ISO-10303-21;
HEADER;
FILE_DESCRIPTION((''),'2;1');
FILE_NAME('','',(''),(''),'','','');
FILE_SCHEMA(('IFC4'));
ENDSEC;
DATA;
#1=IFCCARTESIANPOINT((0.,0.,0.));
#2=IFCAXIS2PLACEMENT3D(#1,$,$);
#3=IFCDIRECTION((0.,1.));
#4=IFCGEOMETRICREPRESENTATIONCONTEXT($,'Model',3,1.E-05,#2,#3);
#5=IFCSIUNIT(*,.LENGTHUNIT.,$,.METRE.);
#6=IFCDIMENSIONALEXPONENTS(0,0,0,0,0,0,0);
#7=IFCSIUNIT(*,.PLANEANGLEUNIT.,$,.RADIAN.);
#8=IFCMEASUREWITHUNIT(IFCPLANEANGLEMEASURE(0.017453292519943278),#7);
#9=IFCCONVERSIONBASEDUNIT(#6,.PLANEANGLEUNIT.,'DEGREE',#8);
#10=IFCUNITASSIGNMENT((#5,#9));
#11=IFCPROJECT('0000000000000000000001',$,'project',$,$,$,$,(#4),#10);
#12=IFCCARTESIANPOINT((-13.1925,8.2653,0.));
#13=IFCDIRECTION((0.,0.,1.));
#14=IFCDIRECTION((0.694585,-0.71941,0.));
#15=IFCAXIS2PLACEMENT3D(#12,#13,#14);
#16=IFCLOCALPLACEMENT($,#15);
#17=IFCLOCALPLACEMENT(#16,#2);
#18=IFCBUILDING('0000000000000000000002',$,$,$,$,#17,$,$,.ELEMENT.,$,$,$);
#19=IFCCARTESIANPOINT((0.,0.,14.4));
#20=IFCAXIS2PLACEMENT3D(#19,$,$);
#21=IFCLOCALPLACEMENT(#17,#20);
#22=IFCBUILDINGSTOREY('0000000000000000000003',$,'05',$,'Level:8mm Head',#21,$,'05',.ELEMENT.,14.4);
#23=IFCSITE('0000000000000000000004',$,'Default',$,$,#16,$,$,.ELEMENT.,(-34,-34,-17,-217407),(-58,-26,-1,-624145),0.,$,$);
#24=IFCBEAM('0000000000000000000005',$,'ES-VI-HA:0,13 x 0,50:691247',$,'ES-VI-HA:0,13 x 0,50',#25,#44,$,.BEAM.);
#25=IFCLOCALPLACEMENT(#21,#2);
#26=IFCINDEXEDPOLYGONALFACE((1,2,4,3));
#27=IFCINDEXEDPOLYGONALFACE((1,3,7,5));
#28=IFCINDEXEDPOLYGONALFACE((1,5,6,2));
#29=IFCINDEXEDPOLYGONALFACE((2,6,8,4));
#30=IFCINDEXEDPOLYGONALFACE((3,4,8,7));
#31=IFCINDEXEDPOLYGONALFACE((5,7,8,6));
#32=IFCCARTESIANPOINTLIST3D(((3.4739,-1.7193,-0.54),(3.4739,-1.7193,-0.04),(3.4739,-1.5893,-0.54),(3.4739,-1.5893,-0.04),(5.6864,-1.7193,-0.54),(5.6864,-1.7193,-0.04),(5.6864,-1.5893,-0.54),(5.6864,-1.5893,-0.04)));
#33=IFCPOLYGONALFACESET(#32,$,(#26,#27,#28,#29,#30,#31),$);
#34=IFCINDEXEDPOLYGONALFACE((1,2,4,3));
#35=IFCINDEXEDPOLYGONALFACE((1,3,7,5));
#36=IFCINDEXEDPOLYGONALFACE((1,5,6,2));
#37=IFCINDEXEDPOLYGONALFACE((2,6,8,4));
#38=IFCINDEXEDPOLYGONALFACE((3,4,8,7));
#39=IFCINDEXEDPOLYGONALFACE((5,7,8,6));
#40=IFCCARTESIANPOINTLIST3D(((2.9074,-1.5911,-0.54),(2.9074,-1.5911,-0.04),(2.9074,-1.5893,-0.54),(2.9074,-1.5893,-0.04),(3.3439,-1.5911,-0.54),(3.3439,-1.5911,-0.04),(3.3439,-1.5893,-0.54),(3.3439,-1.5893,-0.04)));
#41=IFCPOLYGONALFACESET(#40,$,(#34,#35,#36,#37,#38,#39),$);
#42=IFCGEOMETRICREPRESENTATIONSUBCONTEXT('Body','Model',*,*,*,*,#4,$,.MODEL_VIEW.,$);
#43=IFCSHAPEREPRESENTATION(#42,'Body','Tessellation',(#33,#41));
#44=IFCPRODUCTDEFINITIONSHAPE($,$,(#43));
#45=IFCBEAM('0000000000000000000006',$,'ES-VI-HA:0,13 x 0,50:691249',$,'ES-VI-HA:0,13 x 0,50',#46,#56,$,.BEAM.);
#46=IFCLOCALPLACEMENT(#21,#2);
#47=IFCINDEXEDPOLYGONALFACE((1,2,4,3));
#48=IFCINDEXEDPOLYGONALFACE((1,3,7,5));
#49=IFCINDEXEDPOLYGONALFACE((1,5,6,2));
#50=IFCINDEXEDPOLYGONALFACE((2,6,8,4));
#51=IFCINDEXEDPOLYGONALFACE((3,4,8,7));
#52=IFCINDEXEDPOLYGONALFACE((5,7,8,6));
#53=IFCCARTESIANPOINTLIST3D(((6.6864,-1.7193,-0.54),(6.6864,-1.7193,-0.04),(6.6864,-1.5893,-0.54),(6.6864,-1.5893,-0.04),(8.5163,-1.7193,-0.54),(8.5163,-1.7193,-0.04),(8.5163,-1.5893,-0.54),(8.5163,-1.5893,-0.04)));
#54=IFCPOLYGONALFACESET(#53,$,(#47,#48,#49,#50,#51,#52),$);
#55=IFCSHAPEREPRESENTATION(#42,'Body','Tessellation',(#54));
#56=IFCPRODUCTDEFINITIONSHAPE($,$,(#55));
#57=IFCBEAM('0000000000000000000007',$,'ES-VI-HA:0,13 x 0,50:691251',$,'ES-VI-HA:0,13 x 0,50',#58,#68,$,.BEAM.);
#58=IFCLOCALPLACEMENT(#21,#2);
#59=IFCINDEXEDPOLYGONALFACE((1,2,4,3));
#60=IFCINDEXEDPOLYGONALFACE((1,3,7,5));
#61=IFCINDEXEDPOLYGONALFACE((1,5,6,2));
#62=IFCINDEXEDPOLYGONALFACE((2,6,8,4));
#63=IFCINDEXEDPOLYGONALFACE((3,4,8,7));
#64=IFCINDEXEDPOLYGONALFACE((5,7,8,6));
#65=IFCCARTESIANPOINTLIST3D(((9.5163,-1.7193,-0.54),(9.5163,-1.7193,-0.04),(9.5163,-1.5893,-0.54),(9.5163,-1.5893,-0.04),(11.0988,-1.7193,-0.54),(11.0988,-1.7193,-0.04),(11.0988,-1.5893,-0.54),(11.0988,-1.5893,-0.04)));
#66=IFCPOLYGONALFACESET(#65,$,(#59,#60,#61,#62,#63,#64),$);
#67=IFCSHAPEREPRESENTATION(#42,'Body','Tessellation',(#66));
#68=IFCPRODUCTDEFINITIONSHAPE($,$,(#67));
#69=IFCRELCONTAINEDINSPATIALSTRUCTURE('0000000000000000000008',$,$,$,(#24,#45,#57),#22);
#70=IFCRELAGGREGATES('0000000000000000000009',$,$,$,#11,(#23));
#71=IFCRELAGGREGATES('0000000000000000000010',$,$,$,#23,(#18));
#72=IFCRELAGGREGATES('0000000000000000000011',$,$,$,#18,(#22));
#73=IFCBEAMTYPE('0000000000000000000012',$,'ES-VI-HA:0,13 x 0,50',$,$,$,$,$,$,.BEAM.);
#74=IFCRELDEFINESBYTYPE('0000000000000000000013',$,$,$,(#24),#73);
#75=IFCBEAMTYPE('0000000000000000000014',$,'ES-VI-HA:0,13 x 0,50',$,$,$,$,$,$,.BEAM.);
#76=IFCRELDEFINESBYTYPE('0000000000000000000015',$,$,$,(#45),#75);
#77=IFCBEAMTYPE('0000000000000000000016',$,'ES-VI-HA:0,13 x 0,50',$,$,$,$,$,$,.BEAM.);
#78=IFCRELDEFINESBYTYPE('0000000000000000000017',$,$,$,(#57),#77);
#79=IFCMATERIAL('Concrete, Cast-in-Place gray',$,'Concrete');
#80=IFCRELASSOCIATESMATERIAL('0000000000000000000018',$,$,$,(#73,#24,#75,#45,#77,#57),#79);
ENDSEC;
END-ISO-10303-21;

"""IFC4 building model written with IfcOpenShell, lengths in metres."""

from ifc_helpers import new_model, entity, si_unit, converted_unit, direction, frame, origin, place, context, subcontext, project, spatial, indexed_curve, outline, extrude, source, transform, mapped, material, type_object, type_shapes, element, save


model = new_model("IFC4")

# Units and contexts
model_context = context("Model", 3, precision=1e-05, world=origin(), true_north=direction((0.0, 1.0)))
body_context = subcontext(model_context, "Body", "Model", "MODEL_VIEW")
ifc_project = project(units=[si_unit("LENGTHUNIT", "METRE"), converted_unit("PLANEANGLEUNIT", "DEGREE", entity("IfcPlaneAngleMeasure", 0.017453292519943278), si_unit("PLANEANGLEUNIT", "RADIAN"), dimensions=[0, 0, 0, 0, 0, 0, 0])], contexts=[model_context])

# Site, building, storey
site_placement = place(None, frame((-13.1925, 8.2653, 0.0), z_axis=(0.0, 0.0, 1.0), x_axis=(0.694585, -0.71941, 0.0)))
site = spatial("IfcSite", under=ifc_project, at=site_placement, Name="Default", CompositionType="ELEMENT", RefLatitude=(-34, -34, -17, -217407), RefLongitude=(-58, -26, -1, -624145), RefElevation=0.0)
building_placement = place(site_placement, origin())
building = spatial("IfcBuilding", under=site, at=building_placement, CompositionType="ELEMENT")
storey_placement = place(building_placement, frame((0.0, 0.0, 14.4)))
storey = spatial("IfcBuildingStorey", under=building, at=storey_placement, Name="05", ObjectType="Level:8mm Head", LongName="05", CompositionType="ELEMENT", Elevation=14.4)

# Beams
ifc_material_1 = material(Name="Concrete, Cast-in-Place gray", Category="Concrete")
beam_type_1 = type_object("IfcBeamType", Name="ES-VI-HA:0,13 x 0,50", PredefinedType="BEAM", material=ifc_material_1)
shared_shape_1 = source(origin(), body_context, "Body", "SweptSolid", [
    extrude(outline(indexed_curve([(-0.25, -0.065), (0.25, -0.065), (0.25, 0.065), (-0.25, 0.065), (-0.25, -0.065)], self_intersect=False)), frame((3.4739, -1.6543, 14.11), z_axis=(1.0, 0.0, 0.0), x_axis=(0.0, 0.0, -1.0)), (0.0, 0.0, 1.0), 2.2125),
    extrude(outline(indexed_curve([(-0.25, -0.0009), (0.25, -0.0009), (0.25, 0.0009), (-0.25, 0.0009), (-0.25, -0.0009)], self_intersect=False)), frame((2.9074, -1.5902, 14.11), z_axis=(1.0, 0.0, 0.0), x_axis=(0.0, 0.0, -1.0)), (0.0, 0.0, 1.0), 0.4365),
])
type_shapes(beam_type_1, [shared_shape_1])
beam_1_placement = place(storey_placement, frame((0.0, 0.0, -14.4)))
element("IfcBeam", 1, at=beam_1_placement, inside=storey, type_object=beam_type_1, material=ifc_material_1, Name="ES-VI-HA:0,13 x 0,50:691247", ObjectType="ES-VI-HA:0,13 x 0,50", PredefinedType="BEAM", context=body_context, shape_type="MappedRepresentation", body=[
    mapped(shared_shape_1, transform((0.0, 0.0, 0.0), scale=1.0)),
])
beam_type_2 = type_object("IfcBeamType", Name="ES-VI-HA:0,13 x 0,50", PredefinedType="BEAM", material=ifc_material_1)
shared_shape_2 = source(origin(), body_context, "Body", "SweptSolid", [
    extrude(outline(indexed_curve([(-0.25, -0.065), (0.25, -0.065), (0.25, 0.065), (-0.25, 0.065), (-0.25, -0.065)], self_intersect=False)), frame((6.6864, -1.6543, 14.11), z_axis=(1.0, 0.0, 0.0), x_axis=(0.0, 0.0, -1.0)), (0.0, 0.0, 1.0), 1.8299),
])
type_shapes(beam_type_2, [shared_shape_2])
beam_2_placement = place(storey_placement, frame((0.0, 0.0, -14.4)))
element("IfcBeam", 2, at=beam_2_placement, inside=storey, type_object=beam_type_2, material=ifc_material_1, Name="ES-VI-HA:0,13 x 0,50:691249", ObjectType="ES-VI-HA:0,13 x 0,50", PredefinedType="BEAM", context=body_context, shape_type="MappedRepresentation", body=[
    mapped(shared_shape_2, transform((0.0, 0.0, 0.0), scale=1.0)),
])
beam_type_3 = type_object("IfcBeamType", Name="ES-VI-HA:0,13 x 0,50", PredefinedType="BEAM", material=ifc_material_1)
shared_shape_3 = source(origin(), body_context, "Body", "SweptSolid", [
    extrude(outline(indexed_curve([(-0.25, -0.065), (0.25, -0.065), (0.25, 0.065), (-0.25, 0.065), (-0.25, -0.065)], self_intersect=False)), frame((9.5163, -1.6543, 14.11), z_axis=(1.0, 0.0, 0.0), x_axis=(0.0, 0.0, -1.0)), (0.0, 0.0, 1.0), 1.5825),
])
type_shapes(beam_type_3, [shared_shape_3])
beam_3_placement = place(storey_placement, frame((0.0, 0.0, -14.4)))
element("IfcBeam", 3, at=beam_3_placement, inside=storey, type_object=beam_type_3, material=ifc_material_1, Name="ES-VI-HA:0,13 x 0,50:691251", ObjectType="ES-VI-HA:0,13 x 0,50", PredefinedType="BEAM", context=body_context, shape_type="MappedRepresentation", body=[
    mapped(shared_shape_3, transform((0.0, 0.0, 0.0), scale=1.0)),
])

save(model, "model.ifc")
